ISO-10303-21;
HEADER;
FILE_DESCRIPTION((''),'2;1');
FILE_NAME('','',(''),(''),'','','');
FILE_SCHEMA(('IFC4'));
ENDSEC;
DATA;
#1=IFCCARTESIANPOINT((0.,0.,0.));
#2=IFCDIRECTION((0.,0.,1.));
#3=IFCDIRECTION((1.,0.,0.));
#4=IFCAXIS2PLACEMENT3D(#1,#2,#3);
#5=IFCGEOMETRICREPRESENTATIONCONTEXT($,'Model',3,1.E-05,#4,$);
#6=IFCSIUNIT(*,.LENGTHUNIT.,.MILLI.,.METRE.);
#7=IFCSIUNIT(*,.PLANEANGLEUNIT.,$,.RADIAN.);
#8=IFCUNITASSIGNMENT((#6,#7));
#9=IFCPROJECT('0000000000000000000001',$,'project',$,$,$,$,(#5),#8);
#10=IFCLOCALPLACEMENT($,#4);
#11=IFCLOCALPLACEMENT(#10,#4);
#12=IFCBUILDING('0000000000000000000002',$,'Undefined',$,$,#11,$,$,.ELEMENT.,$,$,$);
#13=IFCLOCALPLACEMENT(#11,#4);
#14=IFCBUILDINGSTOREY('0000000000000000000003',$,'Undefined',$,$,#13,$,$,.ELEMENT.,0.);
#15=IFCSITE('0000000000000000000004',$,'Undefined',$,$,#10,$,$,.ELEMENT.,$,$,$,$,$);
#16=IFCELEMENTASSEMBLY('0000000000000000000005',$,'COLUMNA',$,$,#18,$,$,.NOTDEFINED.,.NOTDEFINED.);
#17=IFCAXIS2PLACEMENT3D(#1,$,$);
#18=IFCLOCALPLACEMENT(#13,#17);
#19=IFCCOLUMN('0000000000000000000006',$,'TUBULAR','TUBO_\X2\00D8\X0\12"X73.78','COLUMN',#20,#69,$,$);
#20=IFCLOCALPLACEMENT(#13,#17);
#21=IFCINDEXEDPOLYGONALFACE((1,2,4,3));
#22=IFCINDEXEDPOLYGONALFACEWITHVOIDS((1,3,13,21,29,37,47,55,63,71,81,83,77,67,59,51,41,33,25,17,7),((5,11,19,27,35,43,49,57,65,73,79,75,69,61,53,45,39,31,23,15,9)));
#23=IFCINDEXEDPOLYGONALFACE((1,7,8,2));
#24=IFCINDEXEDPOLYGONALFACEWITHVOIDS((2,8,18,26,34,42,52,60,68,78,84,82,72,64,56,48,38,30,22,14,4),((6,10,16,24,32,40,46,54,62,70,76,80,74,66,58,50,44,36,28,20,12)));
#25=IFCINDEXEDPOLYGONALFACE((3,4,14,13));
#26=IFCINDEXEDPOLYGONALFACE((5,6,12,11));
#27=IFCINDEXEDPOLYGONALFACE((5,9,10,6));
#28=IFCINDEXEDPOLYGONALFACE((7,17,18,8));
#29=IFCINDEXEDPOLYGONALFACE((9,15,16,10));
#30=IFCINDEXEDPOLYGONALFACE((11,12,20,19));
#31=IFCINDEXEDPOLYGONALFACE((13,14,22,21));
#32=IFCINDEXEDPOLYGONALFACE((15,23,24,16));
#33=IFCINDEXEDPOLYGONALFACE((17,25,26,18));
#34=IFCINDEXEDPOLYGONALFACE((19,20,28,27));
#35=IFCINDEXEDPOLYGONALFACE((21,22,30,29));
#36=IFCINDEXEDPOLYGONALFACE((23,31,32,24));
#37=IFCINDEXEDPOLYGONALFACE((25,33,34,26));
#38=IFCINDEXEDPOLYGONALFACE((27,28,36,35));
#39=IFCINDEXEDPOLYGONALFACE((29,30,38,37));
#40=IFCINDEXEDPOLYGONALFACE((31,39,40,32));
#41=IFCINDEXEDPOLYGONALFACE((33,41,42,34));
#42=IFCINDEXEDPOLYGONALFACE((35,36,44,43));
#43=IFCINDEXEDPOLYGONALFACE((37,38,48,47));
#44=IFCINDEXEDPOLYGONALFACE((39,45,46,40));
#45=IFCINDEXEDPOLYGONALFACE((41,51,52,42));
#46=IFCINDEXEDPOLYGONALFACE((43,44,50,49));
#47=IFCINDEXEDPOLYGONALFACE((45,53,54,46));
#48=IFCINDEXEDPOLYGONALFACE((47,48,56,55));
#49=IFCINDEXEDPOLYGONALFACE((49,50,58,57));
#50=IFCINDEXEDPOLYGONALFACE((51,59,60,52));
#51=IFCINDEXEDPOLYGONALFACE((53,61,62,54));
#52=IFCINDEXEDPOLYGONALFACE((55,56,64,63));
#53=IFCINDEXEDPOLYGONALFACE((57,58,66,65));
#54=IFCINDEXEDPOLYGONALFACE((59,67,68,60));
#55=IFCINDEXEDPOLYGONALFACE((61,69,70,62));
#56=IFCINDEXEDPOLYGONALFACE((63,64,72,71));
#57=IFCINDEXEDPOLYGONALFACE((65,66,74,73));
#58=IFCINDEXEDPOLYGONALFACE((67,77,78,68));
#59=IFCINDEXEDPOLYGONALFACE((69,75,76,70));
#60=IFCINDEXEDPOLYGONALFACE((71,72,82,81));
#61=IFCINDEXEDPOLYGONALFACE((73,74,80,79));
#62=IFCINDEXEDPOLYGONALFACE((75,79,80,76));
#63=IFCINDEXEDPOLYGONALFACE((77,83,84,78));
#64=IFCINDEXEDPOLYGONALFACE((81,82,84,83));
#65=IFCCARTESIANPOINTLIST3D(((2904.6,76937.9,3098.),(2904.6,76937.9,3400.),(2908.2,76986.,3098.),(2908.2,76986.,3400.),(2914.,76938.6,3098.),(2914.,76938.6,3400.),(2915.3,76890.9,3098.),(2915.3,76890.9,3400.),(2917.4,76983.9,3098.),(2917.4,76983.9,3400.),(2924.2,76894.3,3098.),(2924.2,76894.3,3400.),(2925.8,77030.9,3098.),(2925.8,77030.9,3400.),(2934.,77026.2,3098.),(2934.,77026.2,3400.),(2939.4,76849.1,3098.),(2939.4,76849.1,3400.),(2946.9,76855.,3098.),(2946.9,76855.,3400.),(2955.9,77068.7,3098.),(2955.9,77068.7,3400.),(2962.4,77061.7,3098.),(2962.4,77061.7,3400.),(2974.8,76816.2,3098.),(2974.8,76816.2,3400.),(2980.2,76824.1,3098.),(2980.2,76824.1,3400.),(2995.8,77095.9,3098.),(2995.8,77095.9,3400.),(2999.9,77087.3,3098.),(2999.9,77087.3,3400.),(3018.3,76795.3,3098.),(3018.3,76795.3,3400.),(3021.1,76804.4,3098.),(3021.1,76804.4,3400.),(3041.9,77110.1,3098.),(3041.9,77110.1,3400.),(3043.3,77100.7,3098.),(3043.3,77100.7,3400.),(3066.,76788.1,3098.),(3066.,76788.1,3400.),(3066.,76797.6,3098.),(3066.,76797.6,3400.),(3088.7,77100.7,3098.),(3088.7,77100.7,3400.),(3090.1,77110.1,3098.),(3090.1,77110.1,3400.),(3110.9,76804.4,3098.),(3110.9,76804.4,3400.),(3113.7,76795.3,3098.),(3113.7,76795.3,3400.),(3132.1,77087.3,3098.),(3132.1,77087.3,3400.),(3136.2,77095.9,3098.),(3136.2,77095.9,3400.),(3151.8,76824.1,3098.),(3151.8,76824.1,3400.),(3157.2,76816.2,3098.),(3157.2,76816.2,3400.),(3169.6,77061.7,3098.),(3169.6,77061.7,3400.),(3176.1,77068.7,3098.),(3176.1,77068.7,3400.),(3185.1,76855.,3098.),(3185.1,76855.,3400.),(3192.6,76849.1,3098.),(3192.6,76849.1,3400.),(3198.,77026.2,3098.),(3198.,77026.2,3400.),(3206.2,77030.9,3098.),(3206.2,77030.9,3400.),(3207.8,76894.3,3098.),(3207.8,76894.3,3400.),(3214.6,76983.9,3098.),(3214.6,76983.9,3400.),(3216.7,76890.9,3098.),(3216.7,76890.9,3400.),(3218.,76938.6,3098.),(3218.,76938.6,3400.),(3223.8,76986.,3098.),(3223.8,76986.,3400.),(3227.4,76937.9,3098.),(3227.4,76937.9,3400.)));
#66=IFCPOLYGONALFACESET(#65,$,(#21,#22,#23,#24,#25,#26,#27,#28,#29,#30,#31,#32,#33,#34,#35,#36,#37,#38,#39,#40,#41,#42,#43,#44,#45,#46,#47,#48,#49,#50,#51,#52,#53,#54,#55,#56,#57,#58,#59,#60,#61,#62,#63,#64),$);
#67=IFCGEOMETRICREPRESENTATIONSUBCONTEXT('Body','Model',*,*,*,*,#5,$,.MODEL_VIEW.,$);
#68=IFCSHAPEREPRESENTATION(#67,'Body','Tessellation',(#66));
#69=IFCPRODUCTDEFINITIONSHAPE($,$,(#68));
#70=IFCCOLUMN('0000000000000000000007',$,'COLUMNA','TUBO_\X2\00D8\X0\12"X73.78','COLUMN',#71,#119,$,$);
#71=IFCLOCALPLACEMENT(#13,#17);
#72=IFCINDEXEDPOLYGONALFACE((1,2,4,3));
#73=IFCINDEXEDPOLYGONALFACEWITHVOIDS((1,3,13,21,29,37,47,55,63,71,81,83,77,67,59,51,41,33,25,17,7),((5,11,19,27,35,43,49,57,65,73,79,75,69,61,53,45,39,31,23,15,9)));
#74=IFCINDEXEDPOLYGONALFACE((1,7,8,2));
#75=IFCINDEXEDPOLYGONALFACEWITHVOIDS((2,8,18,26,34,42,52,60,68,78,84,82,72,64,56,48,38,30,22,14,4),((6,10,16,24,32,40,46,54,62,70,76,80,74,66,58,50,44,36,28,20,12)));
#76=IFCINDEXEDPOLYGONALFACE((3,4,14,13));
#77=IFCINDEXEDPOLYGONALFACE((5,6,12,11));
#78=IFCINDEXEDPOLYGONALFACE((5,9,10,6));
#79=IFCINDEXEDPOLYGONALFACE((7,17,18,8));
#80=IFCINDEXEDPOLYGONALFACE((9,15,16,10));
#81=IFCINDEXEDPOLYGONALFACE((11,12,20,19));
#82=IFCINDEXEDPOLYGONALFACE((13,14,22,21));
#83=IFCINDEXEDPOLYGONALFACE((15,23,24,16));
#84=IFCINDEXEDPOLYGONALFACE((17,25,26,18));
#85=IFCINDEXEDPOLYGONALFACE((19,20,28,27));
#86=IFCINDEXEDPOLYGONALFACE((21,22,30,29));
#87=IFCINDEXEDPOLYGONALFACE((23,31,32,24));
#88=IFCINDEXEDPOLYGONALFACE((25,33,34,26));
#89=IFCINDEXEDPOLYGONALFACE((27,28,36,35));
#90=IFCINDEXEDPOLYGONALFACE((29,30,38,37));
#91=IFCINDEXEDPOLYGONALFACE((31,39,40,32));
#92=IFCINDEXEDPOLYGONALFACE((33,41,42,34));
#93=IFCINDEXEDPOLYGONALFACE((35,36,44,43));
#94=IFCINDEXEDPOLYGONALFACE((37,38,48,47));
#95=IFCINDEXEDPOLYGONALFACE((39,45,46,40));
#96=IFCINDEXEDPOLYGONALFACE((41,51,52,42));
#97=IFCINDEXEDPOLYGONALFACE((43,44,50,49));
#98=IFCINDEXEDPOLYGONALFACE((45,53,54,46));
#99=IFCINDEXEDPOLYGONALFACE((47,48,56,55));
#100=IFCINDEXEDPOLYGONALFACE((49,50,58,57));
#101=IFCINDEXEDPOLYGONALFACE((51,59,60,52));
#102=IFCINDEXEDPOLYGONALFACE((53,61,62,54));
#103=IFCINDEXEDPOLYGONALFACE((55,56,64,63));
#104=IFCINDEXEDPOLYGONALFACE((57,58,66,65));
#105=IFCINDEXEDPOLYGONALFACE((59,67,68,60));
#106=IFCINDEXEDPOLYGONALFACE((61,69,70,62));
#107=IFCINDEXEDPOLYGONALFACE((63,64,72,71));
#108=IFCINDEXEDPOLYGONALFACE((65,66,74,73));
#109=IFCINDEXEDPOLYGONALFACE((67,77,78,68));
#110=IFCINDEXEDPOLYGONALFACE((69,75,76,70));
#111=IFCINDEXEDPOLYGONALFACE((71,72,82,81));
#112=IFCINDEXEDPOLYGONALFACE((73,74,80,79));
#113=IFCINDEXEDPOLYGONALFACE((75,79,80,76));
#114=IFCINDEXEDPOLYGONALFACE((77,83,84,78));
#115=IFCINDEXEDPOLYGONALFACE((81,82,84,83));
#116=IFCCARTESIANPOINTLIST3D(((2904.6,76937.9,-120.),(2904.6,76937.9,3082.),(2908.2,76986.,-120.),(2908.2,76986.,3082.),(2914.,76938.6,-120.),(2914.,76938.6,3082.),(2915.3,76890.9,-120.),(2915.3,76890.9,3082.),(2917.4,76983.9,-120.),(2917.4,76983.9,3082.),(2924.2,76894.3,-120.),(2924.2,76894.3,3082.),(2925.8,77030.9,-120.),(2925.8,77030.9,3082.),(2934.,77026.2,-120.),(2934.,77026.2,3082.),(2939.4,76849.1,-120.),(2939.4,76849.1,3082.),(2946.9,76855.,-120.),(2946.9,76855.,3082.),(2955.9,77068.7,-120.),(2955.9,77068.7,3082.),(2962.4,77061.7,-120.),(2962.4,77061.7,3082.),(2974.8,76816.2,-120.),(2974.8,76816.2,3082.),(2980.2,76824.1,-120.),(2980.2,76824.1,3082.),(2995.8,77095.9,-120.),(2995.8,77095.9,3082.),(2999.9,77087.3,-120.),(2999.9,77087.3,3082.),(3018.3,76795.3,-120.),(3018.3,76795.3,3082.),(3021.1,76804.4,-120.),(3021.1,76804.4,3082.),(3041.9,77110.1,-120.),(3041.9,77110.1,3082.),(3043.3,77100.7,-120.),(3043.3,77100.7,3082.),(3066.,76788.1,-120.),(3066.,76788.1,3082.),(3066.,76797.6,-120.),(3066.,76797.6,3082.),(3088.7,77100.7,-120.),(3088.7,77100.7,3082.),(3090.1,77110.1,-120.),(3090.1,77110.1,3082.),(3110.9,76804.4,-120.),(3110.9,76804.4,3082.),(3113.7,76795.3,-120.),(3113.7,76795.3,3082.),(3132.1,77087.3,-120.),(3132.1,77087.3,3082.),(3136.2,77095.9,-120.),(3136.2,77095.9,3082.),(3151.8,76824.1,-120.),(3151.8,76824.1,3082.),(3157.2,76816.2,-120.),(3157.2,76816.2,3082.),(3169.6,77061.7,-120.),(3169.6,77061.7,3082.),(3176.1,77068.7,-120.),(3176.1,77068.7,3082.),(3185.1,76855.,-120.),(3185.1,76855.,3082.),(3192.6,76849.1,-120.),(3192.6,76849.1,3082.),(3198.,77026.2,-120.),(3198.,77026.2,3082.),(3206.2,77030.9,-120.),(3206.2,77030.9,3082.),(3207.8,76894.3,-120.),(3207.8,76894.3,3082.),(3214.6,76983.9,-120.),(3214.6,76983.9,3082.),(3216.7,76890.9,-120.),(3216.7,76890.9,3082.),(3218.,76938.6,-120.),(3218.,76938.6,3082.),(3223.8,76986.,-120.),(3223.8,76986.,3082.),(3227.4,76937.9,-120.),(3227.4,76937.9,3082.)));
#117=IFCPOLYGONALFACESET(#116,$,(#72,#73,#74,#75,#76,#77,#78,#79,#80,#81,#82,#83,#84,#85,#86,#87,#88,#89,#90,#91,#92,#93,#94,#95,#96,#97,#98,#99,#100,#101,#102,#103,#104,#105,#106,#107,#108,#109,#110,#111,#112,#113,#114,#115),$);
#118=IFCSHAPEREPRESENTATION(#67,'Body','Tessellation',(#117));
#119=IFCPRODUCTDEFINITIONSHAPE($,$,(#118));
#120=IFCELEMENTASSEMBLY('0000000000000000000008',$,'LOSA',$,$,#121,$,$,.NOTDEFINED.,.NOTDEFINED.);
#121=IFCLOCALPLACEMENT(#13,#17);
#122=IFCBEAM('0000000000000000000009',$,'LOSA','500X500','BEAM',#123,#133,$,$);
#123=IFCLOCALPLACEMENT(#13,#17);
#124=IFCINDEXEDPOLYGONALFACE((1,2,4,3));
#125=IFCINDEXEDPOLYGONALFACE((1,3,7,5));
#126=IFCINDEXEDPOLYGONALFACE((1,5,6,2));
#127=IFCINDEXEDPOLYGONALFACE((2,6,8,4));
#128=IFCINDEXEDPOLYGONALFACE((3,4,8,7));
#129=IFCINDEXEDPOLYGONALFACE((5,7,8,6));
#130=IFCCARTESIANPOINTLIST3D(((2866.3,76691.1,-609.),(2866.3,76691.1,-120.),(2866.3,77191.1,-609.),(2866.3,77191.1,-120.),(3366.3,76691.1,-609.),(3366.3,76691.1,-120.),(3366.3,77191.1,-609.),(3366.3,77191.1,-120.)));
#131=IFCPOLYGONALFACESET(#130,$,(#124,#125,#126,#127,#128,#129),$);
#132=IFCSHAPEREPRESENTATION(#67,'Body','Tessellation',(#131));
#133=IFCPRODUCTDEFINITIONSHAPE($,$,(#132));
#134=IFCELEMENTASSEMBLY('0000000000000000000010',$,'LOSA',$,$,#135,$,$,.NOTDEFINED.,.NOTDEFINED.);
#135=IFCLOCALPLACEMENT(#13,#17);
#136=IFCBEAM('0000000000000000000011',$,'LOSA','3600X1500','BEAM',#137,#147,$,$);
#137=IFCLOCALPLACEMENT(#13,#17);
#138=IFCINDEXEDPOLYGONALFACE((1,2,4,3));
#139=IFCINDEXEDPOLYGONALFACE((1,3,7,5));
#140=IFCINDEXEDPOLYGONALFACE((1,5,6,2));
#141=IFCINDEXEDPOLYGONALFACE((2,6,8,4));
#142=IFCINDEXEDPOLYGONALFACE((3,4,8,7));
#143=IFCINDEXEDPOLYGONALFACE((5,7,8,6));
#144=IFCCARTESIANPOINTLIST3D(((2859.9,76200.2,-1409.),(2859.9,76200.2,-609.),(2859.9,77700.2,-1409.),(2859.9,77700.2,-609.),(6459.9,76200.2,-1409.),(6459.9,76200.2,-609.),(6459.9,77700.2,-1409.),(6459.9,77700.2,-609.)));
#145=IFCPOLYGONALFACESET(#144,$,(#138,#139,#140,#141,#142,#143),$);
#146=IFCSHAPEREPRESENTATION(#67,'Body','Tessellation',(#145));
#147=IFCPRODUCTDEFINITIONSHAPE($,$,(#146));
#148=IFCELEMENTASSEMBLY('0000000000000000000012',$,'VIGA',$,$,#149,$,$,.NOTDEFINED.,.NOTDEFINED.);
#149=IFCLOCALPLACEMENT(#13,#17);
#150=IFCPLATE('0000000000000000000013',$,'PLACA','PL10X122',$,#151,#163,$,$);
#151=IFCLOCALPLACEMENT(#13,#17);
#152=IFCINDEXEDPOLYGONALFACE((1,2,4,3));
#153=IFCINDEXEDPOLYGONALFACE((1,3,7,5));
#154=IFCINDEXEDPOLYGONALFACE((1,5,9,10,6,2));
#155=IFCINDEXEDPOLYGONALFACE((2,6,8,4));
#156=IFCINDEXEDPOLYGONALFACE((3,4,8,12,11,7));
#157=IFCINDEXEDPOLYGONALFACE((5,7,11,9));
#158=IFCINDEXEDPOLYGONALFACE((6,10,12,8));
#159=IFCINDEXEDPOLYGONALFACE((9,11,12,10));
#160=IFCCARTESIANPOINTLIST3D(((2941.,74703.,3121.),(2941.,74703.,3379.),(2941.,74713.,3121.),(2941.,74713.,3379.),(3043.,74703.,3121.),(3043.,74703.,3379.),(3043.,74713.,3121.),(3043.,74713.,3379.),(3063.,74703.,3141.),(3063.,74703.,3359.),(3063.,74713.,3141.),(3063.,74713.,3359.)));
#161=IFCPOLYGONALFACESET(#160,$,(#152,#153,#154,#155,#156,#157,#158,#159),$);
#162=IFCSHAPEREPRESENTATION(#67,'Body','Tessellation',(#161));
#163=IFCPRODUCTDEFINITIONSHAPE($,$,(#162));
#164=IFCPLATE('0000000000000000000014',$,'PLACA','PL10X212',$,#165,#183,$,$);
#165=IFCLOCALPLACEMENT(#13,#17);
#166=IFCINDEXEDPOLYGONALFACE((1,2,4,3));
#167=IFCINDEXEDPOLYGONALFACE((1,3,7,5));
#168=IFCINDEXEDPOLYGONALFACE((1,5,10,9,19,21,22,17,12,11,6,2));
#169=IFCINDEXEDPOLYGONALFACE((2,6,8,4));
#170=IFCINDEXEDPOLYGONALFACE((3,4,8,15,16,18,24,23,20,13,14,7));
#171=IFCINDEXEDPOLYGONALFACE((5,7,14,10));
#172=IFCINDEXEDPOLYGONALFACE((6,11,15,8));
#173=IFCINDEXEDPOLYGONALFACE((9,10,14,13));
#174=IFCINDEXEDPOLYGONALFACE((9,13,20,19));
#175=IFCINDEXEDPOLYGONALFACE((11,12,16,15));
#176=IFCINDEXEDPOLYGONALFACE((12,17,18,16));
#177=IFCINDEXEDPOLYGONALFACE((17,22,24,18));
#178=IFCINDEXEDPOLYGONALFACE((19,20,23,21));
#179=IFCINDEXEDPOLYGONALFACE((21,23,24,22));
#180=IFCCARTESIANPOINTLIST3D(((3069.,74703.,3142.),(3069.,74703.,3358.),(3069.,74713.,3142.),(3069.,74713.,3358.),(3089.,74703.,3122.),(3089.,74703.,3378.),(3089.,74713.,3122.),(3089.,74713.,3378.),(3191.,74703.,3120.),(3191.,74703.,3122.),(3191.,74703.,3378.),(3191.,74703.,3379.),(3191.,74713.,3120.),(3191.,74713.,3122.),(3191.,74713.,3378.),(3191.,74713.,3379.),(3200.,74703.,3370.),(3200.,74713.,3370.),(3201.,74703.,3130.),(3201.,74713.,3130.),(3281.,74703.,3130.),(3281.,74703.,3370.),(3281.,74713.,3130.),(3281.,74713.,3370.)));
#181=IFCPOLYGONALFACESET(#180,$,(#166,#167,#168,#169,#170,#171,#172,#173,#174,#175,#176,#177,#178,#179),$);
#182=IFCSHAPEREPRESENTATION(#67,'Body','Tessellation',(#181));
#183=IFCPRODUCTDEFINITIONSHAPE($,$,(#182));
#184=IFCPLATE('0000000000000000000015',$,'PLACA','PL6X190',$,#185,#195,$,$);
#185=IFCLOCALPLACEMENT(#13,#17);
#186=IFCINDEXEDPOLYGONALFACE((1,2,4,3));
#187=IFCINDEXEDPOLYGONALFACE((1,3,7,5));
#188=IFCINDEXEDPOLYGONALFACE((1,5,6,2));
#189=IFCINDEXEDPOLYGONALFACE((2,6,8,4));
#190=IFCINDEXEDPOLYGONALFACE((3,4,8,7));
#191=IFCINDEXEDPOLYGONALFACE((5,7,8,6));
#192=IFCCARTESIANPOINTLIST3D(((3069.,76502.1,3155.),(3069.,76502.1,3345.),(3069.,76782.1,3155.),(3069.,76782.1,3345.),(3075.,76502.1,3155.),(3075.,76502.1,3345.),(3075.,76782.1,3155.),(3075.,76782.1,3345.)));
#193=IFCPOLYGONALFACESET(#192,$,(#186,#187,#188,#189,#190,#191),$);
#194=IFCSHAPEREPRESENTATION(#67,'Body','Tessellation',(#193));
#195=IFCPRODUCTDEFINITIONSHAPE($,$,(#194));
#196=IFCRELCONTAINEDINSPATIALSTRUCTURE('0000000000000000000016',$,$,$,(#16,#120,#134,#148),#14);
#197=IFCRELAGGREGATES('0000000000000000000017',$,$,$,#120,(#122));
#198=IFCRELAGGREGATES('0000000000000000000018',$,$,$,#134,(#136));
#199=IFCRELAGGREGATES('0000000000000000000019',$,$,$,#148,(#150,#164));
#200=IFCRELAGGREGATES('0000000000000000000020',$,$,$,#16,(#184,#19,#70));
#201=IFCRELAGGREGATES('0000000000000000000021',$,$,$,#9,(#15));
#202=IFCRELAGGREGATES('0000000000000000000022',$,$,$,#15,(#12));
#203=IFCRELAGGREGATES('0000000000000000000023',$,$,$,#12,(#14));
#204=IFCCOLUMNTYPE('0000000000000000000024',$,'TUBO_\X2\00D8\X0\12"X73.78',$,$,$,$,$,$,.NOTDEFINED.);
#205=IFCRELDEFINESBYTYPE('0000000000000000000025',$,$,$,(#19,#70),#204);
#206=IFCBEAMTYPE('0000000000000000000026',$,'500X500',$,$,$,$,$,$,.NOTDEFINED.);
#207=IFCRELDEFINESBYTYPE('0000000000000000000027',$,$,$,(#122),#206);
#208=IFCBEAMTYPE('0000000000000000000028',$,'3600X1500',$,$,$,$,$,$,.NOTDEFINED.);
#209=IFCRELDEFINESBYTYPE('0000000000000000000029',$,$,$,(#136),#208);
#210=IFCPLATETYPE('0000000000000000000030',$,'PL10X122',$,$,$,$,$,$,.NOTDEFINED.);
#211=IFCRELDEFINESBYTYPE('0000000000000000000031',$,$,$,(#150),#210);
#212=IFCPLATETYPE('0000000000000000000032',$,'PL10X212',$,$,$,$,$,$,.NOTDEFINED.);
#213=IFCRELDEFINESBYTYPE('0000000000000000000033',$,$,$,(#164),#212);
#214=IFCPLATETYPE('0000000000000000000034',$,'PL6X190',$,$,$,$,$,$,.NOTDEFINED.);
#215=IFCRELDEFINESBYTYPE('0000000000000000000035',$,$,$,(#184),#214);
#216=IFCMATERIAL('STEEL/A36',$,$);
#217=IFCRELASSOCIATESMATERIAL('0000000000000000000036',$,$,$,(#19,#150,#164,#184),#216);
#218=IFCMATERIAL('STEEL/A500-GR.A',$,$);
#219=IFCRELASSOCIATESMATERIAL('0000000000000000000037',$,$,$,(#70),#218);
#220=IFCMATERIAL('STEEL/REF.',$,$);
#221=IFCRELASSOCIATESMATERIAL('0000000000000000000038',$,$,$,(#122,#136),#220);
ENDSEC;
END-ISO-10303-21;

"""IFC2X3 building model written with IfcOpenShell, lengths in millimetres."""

from ifc_helpers import new_model, si_unit, frame, origin_with_axes, origin_2d_with_axis, place, context, subcontext, project, spatial, polyline, rectangle, hollow_circle, outline, extrude, material, type_object, element, aggregate, save


model = new_model("IFC2X3")

# Units and contexts
model_context = context("Model", 3, precision=1e-05, world=origin_with_axes())
body_context = subcontext(model_context, "Body", "Model", "MODEL_VIEW")
ifc_project = project(units=[si_unit("LENGTHUNIT", "METRE", prefix="MILLI"), si_unit("PLANEANGLEUNIT", "RADIAN")], contexts=[model_context])

# Site, building, storey
site_placement = place(None, origin_with_axes())
site = spatial("IfcSite", under=ifc_project, at=site_placement, Name="Undefined", CompositionType="ELEMENT")
building_placement = place(site_placement, origin_with_axes())
building = spatial("IfcBuilding", under=site, at=building_placement, Name="Undefined", CompositionType="ELEMENT")
storey_placement = place(building_placement, origin_with_axes())
storey = spatial("IfcBuildingStorey", under=building, at=storey_placement, Name="Undefined", CompositionType="ELEMENT", Elevation=0.0)

# Element assembly, columns
assembly_1_placement = place(storey_placement, origin_with_axes())
assembly_1 = element("IfcElementAssembly", 1, at=assembly_1_placement, inside=storey, Name="COLUMNA", AssemblyPlace="NOTDEFINED", PredefinedType="NOTDEFINED")
ifc_material_1 = material(Name="STEEL/A36")
column_type = type_object("IfcColumnType", Name="TUBO_Ø12\"X73.78", PredefinedType="NOTDEFINED")
column_1_placement = place(assembly_1_placement, frame((3066.0, 76950.0, 3098.0), z_axis=(0.0, 0.0, 1.0), x_axis=(-1.0, 0.0, 0.0)))
column_1 = element("IfcColumn", 2, at=column_1_placement, type_object=column_type, material=ifc_material_1, Name="TUBULAR", Description="TUBO_Ø12\"X73.78", ObjectType="COLUMN", context=body_context, shape_type="SweptSolid", body=[
    extrude(hollow_circle(Radius=161.9, WallThickness=9.5, at=origin_2d_with_axis()), frame((0.0, 0.0, 302.0), z_axis=(0.0, 0.0, -1.0), x_axis=(0.0, 1.0, 0.0)), (0.0, 0.0, 1.0), 302.0),
])
ifc_material_2 = material(Name="STEEL/A500-GR.A")
column_2_placement = place(assembly_1_placement, frame((3066.0, 76950.0, -120.0), z_axis=(0.0, 0.0, 1.0), x_axis=(-1.0, 0.0, 0.0)))
column_2 = element("IfcColumn", 3, at=column_2_placement, type_object=column_type, material=ifc_material_2, Name="COLUMNA", Description="TUBO_Ø12\"X73.78", ObjectType="COLUMN", context=body_context, shape_type="SweptSolid", body=[
    extrude(hollow_circle(Radius=161.9, WallThickness=9.5, at=origin_2d_with_axis()), frame((0.0, 0.0, 3202.0), z_axis=(0.0, 0.0, -1.0), x_axis=(0.0, 1.0, 0.0)), (0.0, 0.0, 1.0), 3202.0),
])

# Element assemblies, beams
assembly_2_placement = place(storey_placement, origin_with_axes())
assembly_2 = element("IfcElementAssembly", 4, at=assembly_2_placement, inside=storey, Name="LOSA", AssemblyPlace="NOTDEFINED", PredefinedType="NOTDEFINED")
ifc_material_3 = material(Name="STEEL/REF.")
beam_type_1 = type_object("IfcBeamType", Name="500X500", PredefinedType="NOTDEFINED")
beam_1_placement = place(assembly_2_placement, frame((3116.3, 76941.1, -120.0), z_axis=(1.0, 0.0, 0.0), x_axis=(0.0, 0.0, -1.0)))
beam_1 = element("IfcBeam", 5, at=beam_1_placement, type_object=beam_type_1, material=ifc_material_3, Name="LOSA", Description="500X500", ObjectType="BEAM", context=body_context, shape_type="SweptSolid", body=[
    extrude(rectangle(XDim=500.0, YDim=500.0, at=origin_2d_with_axis()), frame((489.0, 0.0, 0.0), z_axis=(-1.0, 0.0, 0.0), x_axis=(0.0, -1.0, 0.0)), (0.0, 0.0, 1.0), 489.0),
])
aggregate(assembly_2, [beam_1])
assembly_3_placement = place(storey_placement, origin_with_axes())
assembly_3 = element("IfcElementAssembly", 6, at=assembly_3_placement, inside=storey, Name="LOSA", AssemblyPlace="NOTDEFINED", PredefinedType="NOTDEFINED")
beam_type_2 = type_object("IfcBeamType", Name="3600X1500", PredefinedType="NOTDEFINED")
beam_2_placement = place(assembly_3_placement, frame((4659.9, 76950.2, -609.0), z_axis=(1.0, 0.0, 0.0), x_axis=(0.0, 0.0, -1.0)))
beam_2 = element("IfcBeam", 7, at=beam_2_placement, type_object=beam_type_2, material=ifc_material_3, Name="LOSA", Description="3600X1500", ObjectType="BEAM", context=body_context, shape_type="SweptSolid", body=[
    extrude(rectangle(XDim=1500.0, YDim=3600.0, at=origin_2d_with_axis()), frame((800.0, 0.0, 0.0), z_axis=(-1.0, 0.0, 0.0), x_axis=(0.0, -1.0, 0.0)), (0.0, 0.0, 1.0), 800.0),
])
aggregate(assembly_3, [beam_2])

# Element assembly, plates
assembly_4_placement = place(storey_placement, origin_with_axes())
assembly_4 = element("IfcElementAssembly", 8, at=assembly_4_placement, inside=storey, Name="VIGA", AssemblyPlace="NOTDEFINED", PredefinedType="NOTDEFINED")
plate_type_1 = type_object("IfcPlateType", Name="PL10X122", PredefinedType="NOTDEFINED")
plate_1_placement = place(assembly_4_placement, frame((3063.0, 74708.0, 3121.0), z_axis=(0.0, 1.0, 0.0), x_axis=(-1.0, 0.0, 0.0)))
plate_1 = element("IfcPlate", 9, at=plate_1_placement, type_object=plate_type_1, material=ifc_material_1, Name="PLACA", Description="PL10X122", context=body_context, shape_type="SweptSolid", body=[
    extrude(outline(polyline([(0.0, 20.0), (20.0, 0.0), (122.0, 0.0), (122.0, 258.0), (20.0, 258.0), (0.0, 238.0), (0.0, 20.0)])), frame((0.0, 0.0, -5.0), z_axis=(0.0, 0.0, 1.0), x_axis=(1.0, 0.0, 0.0)), (0.0, 0.0, 1.0), 10.0),
])
plate_type_2 = type_object("IfcPlateType", Name="PL10X212", PredefinedType="NOTDEFINED")
plate_2_placement = place(assembly_4_placement, frame((3069.0, 74708.0, 3142.0), z_axis=(0.0, -1.0, 0.0), x_axis=(0.707107, 0.0, -0.707107)))
plate_2 = element("IfcPlate", 10, at=plate_2_placement, type_object=plate_type_2, material=ifc_material_1, Name="PLACA", Description="PL10X212", context=body_context, shape_type="SweptSolid", body=[
    extrude(outline(polyline([(0.0, 0.0), (28.3, 0.0), (100.4, 72.1), (101.8, 70.7), (101.8, 84.9), (158.4, 141.4), (-11.3, 311.1), (-68.6, 253.9), (-81.3, 253.9), (-80.6, 253.1), (-152.7, 181.0), (-152.7, 152.7), (0.0, 0.0)])), frame((0.0, 0.0, -5.0), z_axis=(0.0, 0.0, 1.0), x_axis=(1.0, 0.0, 0.0)), (0.0, 0.0, 1.0), 10.0),
])
aggregate(assembly_4, [plate_1, plate_2])

# Plate
plate_type_3 = type_object("IfcPlateType", Name="PL6X190", PredefinedType="NOTDEFINED")
plate_3_placement = place(assembly_1_placement, frame((3072.0, 76502.1, 3250.0), z_axis=(1.0, 0.0, 0.0), x_axis=(0.0, 1.0, 0.0)))
plate_3 = element("IfcPlate", 11, at=plate_3_placement, type_object=plate_type_3, material=ifc_material_1, Name="PLACA", Description="PL6X190", context=body_context, shape_type="SweptSolid", body=[
    extrude(outline(polyline([(0.0, -95.0), (0.0, 95.0), (280.0, 95.0), (280.0, -95.0), (0.0, -95.0)])), frame((0.0, 0.0, -3.0), z_axis=(0.0, 0.0, 1.0), x_axis=(1.0, 0.0, 0.0)), (0.0, 0.0, 1.0), 6.0),
])

aggregate(assembly_1, [plate_3, column_1, column_2])

save(model, "model.ifc")
